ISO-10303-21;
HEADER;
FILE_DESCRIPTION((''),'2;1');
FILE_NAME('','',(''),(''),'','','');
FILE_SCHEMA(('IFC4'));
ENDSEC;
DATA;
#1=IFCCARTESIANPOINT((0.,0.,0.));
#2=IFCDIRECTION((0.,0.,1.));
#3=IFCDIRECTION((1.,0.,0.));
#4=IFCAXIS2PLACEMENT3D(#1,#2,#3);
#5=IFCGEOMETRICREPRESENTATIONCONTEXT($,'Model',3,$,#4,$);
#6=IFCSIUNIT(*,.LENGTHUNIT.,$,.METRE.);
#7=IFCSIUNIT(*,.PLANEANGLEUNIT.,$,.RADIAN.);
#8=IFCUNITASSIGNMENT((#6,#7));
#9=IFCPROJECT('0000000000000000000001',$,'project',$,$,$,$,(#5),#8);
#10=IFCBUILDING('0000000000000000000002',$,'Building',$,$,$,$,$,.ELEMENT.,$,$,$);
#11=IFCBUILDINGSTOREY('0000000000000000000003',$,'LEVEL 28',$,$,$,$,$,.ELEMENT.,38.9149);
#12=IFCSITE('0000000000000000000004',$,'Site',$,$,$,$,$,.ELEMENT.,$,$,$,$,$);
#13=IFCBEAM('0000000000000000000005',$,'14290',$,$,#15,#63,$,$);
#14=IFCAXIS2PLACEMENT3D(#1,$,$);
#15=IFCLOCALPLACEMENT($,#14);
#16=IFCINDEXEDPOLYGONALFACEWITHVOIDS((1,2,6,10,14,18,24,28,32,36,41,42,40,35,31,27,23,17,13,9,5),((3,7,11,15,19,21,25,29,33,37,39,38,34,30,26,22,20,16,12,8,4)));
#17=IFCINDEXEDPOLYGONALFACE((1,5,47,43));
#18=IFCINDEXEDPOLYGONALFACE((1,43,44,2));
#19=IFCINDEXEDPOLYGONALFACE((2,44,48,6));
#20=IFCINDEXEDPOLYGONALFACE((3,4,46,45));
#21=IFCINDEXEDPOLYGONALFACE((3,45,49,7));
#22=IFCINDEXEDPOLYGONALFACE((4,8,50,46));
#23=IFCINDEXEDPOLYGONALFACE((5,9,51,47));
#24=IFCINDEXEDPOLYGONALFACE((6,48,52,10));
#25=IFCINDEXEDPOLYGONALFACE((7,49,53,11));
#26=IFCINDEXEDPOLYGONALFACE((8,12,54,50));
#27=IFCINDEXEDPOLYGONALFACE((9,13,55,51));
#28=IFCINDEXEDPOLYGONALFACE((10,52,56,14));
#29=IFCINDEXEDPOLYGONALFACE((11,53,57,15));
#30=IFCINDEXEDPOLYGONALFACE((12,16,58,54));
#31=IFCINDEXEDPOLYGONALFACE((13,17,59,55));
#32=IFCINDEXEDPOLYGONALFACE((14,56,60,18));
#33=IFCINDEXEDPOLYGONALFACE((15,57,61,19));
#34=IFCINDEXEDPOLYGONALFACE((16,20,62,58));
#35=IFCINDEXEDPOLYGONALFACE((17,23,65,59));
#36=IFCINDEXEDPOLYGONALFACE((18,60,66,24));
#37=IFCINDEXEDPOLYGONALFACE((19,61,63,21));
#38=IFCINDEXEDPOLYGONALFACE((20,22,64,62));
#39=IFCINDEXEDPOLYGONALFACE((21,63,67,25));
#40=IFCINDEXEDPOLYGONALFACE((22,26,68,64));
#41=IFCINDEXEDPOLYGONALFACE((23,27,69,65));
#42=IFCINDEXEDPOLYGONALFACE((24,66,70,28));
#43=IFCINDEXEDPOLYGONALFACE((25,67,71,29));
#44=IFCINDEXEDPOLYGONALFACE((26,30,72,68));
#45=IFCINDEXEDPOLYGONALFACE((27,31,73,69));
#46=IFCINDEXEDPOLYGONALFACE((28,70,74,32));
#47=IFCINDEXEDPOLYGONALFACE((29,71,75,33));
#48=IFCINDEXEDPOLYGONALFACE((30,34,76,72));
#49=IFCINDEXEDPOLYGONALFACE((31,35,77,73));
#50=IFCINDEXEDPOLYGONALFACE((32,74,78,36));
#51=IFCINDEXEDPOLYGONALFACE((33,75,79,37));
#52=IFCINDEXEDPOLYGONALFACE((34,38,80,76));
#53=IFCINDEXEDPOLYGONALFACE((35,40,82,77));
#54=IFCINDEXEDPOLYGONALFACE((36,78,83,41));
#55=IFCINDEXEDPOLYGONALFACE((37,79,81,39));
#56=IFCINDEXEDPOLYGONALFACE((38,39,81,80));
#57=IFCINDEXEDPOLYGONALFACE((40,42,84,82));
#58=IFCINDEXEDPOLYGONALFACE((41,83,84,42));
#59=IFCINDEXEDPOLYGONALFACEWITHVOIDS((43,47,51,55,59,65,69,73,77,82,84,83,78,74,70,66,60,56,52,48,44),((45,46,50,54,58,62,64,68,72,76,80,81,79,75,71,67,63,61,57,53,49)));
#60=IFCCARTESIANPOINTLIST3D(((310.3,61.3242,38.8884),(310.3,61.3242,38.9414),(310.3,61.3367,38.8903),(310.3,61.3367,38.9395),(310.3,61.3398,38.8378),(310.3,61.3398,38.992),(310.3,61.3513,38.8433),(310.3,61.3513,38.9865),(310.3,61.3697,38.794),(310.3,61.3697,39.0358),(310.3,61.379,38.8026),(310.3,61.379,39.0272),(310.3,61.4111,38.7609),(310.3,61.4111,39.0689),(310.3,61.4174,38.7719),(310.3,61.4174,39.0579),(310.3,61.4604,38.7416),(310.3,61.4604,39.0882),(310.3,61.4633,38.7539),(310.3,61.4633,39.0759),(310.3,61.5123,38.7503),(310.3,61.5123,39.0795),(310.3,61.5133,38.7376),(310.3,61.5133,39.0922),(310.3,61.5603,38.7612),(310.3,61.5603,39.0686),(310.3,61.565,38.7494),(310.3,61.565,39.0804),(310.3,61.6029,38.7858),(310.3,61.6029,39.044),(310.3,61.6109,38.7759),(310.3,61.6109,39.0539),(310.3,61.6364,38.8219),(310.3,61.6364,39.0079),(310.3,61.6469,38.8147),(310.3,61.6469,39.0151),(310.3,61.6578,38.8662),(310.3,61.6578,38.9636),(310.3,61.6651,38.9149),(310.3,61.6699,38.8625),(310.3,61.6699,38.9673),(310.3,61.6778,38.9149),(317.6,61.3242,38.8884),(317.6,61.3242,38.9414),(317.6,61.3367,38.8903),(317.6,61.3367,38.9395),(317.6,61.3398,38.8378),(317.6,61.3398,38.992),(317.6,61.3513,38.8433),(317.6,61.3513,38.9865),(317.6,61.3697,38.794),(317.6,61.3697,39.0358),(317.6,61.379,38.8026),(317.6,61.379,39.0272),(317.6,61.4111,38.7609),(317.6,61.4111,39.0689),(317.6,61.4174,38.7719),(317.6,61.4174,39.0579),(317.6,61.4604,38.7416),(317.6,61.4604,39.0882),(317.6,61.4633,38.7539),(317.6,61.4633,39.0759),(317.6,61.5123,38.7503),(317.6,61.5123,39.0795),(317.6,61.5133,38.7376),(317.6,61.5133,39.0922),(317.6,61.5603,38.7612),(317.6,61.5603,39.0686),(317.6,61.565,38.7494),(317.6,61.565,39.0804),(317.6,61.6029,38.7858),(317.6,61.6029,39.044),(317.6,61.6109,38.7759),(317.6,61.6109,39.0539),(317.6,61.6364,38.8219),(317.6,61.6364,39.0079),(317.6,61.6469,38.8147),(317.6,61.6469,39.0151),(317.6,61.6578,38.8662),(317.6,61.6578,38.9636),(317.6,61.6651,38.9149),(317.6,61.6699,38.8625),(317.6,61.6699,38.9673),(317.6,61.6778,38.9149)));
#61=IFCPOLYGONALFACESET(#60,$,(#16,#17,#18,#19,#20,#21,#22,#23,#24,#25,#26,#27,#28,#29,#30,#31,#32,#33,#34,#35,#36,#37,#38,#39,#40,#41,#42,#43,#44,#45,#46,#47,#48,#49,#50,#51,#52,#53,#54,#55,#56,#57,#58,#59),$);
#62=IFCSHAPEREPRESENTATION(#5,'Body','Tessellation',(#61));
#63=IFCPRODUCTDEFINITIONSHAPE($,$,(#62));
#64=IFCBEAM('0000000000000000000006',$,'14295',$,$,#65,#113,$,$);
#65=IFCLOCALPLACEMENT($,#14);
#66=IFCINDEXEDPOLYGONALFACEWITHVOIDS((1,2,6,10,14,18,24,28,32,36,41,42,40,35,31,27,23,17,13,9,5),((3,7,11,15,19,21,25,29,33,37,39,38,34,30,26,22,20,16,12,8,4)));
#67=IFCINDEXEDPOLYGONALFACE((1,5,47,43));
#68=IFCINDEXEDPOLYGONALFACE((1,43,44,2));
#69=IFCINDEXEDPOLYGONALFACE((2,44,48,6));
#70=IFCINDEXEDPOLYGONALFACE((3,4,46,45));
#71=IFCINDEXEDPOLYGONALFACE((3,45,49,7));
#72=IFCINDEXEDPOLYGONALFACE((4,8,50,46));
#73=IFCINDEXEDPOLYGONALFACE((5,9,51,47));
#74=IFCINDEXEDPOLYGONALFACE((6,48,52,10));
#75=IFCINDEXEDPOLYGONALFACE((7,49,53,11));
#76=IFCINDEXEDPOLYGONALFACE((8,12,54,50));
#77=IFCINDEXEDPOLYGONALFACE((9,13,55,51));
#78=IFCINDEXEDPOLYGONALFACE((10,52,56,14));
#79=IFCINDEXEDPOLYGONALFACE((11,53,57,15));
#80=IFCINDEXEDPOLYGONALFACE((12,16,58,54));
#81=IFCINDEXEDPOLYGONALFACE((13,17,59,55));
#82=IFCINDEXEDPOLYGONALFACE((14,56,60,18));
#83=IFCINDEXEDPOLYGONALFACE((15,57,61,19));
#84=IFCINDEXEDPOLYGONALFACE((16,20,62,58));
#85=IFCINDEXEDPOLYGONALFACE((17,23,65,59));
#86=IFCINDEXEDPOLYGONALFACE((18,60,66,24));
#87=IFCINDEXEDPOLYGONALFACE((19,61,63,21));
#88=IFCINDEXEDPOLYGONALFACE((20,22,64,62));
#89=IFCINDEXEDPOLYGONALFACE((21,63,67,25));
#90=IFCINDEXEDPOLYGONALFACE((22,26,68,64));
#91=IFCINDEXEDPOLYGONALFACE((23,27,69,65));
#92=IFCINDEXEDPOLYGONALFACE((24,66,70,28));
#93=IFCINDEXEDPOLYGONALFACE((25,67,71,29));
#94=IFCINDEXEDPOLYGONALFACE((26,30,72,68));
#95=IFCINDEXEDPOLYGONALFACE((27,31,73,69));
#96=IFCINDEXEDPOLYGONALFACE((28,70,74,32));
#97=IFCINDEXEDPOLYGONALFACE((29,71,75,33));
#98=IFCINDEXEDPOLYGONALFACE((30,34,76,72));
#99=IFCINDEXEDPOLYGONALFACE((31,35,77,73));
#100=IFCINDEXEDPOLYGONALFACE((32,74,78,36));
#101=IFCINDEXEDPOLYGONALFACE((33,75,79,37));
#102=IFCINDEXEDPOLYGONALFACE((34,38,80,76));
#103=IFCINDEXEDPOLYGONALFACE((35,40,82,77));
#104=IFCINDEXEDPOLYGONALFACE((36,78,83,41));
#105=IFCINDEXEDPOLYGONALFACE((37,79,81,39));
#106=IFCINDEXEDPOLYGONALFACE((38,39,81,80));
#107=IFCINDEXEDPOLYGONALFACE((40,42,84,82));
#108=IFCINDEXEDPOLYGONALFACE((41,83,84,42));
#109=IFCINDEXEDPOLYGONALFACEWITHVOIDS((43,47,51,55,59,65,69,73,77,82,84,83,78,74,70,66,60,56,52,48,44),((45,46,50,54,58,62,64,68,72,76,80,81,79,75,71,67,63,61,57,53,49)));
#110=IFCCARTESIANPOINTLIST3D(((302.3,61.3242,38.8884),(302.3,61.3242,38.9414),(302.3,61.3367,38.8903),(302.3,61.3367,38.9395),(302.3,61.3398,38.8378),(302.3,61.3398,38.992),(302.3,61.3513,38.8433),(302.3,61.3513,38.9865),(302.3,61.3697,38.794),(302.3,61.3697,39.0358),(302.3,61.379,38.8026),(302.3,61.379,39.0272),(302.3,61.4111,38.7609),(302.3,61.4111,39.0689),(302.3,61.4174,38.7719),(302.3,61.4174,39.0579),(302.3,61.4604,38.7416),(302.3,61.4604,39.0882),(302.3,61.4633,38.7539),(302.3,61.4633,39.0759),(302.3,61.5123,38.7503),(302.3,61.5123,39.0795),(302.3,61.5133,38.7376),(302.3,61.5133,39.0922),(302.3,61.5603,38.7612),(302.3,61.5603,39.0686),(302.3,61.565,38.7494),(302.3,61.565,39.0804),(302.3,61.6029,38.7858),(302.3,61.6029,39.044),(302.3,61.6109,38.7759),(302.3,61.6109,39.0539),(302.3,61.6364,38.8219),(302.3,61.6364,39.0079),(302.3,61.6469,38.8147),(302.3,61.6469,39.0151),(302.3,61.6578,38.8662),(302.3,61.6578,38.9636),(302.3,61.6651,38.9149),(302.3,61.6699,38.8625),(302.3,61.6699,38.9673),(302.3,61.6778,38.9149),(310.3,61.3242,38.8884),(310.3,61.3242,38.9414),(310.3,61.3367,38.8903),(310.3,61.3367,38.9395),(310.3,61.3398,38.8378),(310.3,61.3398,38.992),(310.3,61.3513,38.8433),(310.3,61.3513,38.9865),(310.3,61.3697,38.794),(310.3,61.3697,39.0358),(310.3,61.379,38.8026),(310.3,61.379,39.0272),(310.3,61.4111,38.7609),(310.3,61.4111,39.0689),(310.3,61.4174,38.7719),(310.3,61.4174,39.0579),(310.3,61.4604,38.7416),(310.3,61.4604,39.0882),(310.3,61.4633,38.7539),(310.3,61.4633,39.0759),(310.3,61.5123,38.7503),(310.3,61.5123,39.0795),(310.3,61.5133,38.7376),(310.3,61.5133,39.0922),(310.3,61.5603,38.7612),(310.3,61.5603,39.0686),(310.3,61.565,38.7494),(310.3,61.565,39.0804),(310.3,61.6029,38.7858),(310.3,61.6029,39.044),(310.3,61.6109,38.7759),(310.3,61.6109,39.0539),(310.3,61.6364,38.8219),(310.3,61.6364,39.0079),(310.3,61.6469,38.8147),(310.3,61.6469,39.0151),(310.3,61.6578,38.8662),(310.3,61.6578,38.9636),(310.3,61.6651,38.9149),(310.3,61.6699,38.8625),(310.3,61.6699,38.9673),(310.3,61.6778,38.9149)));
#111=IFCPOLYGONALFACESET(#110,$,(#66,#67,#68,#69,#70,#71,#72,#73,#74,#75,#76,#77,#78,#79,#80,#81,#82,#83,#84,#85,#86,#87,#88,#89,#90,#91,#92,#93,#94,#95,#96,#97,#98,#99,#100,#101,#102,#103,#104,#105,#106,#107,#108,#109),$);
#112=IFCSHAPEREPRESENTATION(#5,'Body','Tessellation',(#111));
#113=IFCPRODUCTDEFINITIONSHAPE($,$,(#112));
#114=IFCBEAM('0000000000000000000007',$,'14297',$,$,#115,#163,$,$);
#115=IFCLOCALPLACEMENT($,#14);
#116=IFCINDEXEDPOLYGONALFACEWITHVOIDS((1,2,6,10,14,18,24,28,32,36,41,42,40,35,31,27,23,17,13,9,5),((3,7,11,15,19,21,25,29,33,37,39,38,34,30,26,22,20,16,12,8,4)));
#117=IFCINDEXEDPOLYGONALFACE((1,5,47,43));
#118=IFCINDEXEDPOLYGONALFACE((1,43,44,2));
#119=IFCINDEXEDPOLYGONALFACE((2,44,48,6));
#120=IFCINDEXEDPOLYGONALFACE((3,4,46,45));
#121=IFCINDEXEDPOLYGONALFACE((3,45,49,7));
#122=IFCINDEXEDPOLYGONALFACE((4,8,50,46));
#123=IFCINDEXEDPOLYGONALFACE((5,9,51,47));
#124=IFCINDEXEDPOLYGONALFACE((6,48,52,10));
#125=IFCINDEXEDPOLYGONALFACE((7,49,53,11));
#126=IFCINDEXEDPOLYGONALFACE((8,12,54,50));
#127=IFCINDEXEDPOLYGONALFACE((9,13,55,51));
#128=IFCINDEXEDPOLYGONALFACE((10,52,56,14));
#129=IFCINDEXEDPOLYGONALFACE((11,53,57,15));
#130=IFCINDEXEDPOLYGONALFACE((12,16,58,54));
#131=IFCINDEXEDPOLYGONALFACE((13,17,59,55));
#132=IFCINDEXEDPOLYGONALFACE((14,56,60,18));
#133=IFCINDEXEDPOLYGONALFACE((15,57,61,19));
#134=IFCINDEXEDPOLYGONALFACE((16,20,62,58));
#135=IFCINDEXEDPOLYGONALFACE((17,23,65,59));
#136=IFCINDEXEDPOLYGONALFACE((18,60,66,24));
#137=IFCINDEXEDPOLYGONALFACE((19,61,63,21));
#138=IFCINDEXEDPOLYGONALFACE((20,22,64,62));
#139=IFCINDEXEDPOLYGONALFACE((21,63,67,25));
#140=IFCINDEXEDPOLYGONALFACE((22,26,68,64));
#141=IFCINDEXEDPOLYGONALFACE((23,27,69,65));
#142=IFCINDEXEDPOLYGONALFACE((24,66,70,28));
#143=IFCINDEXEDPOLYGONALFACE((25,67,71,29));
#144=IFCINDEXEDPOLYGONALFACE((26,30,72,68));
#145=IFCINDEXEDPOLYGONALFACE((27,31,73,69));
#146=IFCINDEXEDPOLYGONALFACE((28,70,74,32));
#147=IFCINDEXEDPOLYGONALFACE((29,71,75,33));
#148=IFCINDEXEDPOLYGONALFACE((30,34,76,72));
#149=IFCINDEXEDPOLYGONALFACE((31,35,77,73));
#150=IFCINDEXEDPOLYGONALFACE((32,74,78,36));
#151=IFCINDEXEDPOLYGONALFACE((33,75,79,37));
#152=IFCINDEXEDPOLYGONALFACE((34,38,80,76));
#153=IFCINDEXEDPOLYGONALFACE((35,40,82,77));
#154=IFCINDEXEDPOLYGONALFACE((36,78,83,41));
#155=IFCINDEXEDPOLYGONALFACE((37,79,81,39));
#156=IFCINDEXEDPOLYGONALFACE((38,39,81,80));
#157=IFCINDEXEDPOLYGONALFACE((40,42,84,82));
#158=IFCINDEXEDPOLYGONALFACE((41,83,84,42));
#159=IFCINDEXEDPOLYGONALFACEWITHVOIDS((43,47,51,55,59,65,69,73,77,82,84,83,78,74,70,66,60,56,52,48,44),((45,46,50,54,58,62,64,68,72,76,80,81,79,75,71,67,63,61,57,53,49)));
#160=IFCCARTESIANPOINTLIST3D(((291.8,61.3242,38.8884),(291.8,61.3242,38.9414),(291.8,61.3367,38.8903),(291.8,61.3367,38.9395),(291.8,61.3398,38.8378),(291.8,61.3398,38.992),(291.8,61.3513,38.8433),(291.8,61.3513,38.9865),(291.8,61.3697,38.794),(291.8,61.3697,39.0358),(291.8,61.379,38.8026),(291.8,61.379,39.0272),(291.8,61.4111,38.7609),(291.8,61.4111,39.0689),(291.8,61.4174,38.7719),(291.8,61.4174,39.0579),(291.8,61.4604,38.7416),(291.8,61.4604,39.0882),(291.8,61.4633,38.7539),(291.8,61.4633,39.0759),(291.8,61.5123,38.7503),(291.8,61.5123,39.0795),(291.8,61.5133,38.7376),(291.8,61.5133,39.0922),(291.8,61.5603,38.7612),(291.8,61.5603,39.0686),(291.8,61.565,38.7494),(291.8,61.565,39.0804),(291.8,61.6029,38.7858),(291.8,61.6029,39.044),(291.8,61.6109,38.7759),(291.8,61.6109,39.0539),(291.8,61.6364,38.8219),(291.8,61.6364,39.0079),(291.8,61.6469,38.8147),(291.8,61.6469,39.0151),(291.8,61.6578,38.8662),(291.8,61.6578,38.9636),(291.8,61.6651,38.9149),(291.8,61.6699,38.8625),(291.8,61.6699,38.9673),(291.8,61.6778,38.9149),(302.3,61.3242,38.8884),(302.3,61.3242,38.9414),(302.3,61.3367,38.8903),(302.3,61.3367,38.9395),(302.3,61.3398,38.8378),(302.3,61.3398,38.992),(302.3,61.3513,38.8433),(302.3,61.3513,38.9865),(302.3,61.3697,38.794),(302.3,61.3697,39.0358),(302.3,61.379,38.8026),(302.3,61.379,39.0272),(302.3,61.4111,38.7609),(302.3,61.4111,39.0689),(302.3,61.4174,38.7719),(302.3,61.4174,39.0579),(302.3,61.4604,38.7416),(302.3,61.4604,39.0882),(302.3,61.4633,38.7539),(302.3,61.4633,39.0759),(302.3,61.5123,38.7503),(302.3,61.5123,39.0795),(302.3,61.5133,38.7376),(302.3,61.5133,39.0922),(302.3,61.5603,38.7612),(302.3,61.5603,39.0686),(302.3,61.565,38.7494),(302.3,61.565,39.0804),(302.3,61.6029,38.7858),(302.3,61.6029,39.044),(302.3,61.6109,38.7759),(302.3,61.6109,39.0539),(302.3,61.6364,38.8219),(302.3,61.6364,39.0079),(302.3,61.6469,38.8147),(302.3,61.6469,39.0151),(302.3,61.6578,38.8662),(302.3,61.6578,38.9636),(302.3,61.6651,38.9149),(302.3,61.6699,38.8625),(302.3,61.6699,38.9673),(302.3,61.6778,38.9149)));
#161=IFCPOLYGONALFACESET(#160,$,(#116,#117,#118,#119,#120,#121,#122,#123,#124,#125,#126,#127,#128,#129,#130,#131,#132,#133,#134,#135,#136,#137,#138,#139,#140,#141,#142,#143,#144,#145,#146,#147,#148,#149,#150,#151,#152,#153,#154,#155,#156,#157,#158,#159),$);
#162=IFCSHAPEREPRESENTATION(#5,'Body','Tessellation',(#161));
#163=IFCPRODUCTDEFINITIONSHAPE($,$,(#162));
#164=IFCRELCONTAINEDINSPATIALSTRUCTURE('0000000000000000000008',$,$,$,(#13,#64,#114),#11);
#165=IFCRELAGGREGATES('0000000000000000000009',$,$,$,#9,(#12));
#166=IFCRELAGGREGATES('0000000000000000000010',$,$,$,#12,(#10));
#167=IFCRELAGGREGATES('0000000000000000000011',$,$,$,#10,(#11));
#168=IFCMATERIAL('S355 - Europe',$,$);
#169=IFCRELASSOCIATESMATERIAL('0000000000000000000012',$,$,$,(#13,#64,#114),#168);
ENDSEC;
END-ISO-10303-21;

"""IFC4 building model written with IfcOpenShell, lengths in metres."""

from ifc_helpers import new_model, si_unit, frame, origin_with_axes, origin_2d_with_axis, place, context, project, spatial, hollow_circle, extrude, material, material_profile, profile_set, profile_usage, element, save


model = new_model("IFC4")

# Units and contexts
model_context = context("Model", 3, world=origin_with_axes())
ifc_project = project(units=[si_unit("LENGTHUNIT", "METRE"), si_unit("PLANEANGLEUNIT", "RADIAN")], contexts=[model_context])

# Site, building, storey
site = spatial("IfcSite", under=ifc_project, Name="Site", CompositionType="ELEMENT")
building = spatial("IfcBuilding", under=site, Name="Building", CompositionType="ELEMENT")
storey = spatial("IfcBuildingStorey", under=building, Name="LEVEL 28", CompositionType="ELEMENT", Elevation=38.9149)

# Beams
ifc_material = material(Name="S355 - Europe")
ifc_material_profile_1 = material_profile(ifc_material, hollow_circle(Radius=0.1778, WallThickness=0.0127, at=origin_2d_with_axis()))
ifc_profile_set_1 = profile_set([ifc_material_profile_1])
ifc_profile_usage_1 = profile_usage(ifc_profile_set_1, cardinal=10)
beam_1_placement = place(None, frame((310.3, 61.5, 38.9149), z_axis=(1.0, 0.0, 0.0), x_axis=(0.0, 1.0, 0.0)))
element("IfcBeam", 1, at=beam_1_placement, inside=storey, material=ifc_profile_usage_1, Name="14290", context=model_context, shape_type="SweptSolid", body=[
    extrude(hollow_circle(Radius=0.1778, WallThickness=0.0127, at=origin_2d_with_axis()), origin_with_axes(), (0.0, 0.0, 1.0), 7.3),
])
ifc_material_profile_2 = material_profile(ifc_material, hollow_circle(Radius=0.1778, WallThickness=0.0127, at=origin_2d_with_axis()))
ifc_profile_set_2 = profile_set([ifc_material_profile_2])
ifc_profile_usage_2 = profile_usage(ifc_profile_set_2, cardinal=10)
beam_2_placement = place(None, frame((302.3, 61.5, 38.9149), z_axis=(1.0, 0.0, 0.0), x_axis=(0.0, 1.0, 0.0)))
element("IfcBeam", 2, at=beam_2_placement, inside=storey, material=ifc_profile_usage_2, Name="14295", context=model_context, shape_type="SweptSolid", body=[
    extrude(hollow_circle(Radius=0.1778, WallThickness=0.0127, at=origin_2d_with_axis()), origin_with_axes(), (0.0, 0.0, 1.0), 8.0),
])
ifc_material_profile_3 = material_profile(ifc_material, hollow_circle(Radius=0.1778, WallThickness=0.0127, at=origin_2d_with_axis()))
ifc_profile_set_3 = profile_set([ifc_material_profile_3])
ifc_profile_usage_3 = profile_usage(ifc_profile_set_3, cardinal=10)
beam_3_placement = place(None, frame((291.8, 61.5, 38.9149), z_axis=(1.0, 0.0, 0.0), x_axis=(0.0, 1.0, 0.0)))
element("IfcBeam", 3, at=beam_3_placement, inside=storey, material=ifc_profile_usage_3, Name="14297", context=model_context, shape_type="SweptSolid", body=[
    extrude(hollow_circle(Radius=0.1778, WallThickness=0.0127, at=origin_2d_with_axis()), origin_with_axes(), (0.0, 0.0, 1.0), 10.5),
])

save(model, "model.ifc")
